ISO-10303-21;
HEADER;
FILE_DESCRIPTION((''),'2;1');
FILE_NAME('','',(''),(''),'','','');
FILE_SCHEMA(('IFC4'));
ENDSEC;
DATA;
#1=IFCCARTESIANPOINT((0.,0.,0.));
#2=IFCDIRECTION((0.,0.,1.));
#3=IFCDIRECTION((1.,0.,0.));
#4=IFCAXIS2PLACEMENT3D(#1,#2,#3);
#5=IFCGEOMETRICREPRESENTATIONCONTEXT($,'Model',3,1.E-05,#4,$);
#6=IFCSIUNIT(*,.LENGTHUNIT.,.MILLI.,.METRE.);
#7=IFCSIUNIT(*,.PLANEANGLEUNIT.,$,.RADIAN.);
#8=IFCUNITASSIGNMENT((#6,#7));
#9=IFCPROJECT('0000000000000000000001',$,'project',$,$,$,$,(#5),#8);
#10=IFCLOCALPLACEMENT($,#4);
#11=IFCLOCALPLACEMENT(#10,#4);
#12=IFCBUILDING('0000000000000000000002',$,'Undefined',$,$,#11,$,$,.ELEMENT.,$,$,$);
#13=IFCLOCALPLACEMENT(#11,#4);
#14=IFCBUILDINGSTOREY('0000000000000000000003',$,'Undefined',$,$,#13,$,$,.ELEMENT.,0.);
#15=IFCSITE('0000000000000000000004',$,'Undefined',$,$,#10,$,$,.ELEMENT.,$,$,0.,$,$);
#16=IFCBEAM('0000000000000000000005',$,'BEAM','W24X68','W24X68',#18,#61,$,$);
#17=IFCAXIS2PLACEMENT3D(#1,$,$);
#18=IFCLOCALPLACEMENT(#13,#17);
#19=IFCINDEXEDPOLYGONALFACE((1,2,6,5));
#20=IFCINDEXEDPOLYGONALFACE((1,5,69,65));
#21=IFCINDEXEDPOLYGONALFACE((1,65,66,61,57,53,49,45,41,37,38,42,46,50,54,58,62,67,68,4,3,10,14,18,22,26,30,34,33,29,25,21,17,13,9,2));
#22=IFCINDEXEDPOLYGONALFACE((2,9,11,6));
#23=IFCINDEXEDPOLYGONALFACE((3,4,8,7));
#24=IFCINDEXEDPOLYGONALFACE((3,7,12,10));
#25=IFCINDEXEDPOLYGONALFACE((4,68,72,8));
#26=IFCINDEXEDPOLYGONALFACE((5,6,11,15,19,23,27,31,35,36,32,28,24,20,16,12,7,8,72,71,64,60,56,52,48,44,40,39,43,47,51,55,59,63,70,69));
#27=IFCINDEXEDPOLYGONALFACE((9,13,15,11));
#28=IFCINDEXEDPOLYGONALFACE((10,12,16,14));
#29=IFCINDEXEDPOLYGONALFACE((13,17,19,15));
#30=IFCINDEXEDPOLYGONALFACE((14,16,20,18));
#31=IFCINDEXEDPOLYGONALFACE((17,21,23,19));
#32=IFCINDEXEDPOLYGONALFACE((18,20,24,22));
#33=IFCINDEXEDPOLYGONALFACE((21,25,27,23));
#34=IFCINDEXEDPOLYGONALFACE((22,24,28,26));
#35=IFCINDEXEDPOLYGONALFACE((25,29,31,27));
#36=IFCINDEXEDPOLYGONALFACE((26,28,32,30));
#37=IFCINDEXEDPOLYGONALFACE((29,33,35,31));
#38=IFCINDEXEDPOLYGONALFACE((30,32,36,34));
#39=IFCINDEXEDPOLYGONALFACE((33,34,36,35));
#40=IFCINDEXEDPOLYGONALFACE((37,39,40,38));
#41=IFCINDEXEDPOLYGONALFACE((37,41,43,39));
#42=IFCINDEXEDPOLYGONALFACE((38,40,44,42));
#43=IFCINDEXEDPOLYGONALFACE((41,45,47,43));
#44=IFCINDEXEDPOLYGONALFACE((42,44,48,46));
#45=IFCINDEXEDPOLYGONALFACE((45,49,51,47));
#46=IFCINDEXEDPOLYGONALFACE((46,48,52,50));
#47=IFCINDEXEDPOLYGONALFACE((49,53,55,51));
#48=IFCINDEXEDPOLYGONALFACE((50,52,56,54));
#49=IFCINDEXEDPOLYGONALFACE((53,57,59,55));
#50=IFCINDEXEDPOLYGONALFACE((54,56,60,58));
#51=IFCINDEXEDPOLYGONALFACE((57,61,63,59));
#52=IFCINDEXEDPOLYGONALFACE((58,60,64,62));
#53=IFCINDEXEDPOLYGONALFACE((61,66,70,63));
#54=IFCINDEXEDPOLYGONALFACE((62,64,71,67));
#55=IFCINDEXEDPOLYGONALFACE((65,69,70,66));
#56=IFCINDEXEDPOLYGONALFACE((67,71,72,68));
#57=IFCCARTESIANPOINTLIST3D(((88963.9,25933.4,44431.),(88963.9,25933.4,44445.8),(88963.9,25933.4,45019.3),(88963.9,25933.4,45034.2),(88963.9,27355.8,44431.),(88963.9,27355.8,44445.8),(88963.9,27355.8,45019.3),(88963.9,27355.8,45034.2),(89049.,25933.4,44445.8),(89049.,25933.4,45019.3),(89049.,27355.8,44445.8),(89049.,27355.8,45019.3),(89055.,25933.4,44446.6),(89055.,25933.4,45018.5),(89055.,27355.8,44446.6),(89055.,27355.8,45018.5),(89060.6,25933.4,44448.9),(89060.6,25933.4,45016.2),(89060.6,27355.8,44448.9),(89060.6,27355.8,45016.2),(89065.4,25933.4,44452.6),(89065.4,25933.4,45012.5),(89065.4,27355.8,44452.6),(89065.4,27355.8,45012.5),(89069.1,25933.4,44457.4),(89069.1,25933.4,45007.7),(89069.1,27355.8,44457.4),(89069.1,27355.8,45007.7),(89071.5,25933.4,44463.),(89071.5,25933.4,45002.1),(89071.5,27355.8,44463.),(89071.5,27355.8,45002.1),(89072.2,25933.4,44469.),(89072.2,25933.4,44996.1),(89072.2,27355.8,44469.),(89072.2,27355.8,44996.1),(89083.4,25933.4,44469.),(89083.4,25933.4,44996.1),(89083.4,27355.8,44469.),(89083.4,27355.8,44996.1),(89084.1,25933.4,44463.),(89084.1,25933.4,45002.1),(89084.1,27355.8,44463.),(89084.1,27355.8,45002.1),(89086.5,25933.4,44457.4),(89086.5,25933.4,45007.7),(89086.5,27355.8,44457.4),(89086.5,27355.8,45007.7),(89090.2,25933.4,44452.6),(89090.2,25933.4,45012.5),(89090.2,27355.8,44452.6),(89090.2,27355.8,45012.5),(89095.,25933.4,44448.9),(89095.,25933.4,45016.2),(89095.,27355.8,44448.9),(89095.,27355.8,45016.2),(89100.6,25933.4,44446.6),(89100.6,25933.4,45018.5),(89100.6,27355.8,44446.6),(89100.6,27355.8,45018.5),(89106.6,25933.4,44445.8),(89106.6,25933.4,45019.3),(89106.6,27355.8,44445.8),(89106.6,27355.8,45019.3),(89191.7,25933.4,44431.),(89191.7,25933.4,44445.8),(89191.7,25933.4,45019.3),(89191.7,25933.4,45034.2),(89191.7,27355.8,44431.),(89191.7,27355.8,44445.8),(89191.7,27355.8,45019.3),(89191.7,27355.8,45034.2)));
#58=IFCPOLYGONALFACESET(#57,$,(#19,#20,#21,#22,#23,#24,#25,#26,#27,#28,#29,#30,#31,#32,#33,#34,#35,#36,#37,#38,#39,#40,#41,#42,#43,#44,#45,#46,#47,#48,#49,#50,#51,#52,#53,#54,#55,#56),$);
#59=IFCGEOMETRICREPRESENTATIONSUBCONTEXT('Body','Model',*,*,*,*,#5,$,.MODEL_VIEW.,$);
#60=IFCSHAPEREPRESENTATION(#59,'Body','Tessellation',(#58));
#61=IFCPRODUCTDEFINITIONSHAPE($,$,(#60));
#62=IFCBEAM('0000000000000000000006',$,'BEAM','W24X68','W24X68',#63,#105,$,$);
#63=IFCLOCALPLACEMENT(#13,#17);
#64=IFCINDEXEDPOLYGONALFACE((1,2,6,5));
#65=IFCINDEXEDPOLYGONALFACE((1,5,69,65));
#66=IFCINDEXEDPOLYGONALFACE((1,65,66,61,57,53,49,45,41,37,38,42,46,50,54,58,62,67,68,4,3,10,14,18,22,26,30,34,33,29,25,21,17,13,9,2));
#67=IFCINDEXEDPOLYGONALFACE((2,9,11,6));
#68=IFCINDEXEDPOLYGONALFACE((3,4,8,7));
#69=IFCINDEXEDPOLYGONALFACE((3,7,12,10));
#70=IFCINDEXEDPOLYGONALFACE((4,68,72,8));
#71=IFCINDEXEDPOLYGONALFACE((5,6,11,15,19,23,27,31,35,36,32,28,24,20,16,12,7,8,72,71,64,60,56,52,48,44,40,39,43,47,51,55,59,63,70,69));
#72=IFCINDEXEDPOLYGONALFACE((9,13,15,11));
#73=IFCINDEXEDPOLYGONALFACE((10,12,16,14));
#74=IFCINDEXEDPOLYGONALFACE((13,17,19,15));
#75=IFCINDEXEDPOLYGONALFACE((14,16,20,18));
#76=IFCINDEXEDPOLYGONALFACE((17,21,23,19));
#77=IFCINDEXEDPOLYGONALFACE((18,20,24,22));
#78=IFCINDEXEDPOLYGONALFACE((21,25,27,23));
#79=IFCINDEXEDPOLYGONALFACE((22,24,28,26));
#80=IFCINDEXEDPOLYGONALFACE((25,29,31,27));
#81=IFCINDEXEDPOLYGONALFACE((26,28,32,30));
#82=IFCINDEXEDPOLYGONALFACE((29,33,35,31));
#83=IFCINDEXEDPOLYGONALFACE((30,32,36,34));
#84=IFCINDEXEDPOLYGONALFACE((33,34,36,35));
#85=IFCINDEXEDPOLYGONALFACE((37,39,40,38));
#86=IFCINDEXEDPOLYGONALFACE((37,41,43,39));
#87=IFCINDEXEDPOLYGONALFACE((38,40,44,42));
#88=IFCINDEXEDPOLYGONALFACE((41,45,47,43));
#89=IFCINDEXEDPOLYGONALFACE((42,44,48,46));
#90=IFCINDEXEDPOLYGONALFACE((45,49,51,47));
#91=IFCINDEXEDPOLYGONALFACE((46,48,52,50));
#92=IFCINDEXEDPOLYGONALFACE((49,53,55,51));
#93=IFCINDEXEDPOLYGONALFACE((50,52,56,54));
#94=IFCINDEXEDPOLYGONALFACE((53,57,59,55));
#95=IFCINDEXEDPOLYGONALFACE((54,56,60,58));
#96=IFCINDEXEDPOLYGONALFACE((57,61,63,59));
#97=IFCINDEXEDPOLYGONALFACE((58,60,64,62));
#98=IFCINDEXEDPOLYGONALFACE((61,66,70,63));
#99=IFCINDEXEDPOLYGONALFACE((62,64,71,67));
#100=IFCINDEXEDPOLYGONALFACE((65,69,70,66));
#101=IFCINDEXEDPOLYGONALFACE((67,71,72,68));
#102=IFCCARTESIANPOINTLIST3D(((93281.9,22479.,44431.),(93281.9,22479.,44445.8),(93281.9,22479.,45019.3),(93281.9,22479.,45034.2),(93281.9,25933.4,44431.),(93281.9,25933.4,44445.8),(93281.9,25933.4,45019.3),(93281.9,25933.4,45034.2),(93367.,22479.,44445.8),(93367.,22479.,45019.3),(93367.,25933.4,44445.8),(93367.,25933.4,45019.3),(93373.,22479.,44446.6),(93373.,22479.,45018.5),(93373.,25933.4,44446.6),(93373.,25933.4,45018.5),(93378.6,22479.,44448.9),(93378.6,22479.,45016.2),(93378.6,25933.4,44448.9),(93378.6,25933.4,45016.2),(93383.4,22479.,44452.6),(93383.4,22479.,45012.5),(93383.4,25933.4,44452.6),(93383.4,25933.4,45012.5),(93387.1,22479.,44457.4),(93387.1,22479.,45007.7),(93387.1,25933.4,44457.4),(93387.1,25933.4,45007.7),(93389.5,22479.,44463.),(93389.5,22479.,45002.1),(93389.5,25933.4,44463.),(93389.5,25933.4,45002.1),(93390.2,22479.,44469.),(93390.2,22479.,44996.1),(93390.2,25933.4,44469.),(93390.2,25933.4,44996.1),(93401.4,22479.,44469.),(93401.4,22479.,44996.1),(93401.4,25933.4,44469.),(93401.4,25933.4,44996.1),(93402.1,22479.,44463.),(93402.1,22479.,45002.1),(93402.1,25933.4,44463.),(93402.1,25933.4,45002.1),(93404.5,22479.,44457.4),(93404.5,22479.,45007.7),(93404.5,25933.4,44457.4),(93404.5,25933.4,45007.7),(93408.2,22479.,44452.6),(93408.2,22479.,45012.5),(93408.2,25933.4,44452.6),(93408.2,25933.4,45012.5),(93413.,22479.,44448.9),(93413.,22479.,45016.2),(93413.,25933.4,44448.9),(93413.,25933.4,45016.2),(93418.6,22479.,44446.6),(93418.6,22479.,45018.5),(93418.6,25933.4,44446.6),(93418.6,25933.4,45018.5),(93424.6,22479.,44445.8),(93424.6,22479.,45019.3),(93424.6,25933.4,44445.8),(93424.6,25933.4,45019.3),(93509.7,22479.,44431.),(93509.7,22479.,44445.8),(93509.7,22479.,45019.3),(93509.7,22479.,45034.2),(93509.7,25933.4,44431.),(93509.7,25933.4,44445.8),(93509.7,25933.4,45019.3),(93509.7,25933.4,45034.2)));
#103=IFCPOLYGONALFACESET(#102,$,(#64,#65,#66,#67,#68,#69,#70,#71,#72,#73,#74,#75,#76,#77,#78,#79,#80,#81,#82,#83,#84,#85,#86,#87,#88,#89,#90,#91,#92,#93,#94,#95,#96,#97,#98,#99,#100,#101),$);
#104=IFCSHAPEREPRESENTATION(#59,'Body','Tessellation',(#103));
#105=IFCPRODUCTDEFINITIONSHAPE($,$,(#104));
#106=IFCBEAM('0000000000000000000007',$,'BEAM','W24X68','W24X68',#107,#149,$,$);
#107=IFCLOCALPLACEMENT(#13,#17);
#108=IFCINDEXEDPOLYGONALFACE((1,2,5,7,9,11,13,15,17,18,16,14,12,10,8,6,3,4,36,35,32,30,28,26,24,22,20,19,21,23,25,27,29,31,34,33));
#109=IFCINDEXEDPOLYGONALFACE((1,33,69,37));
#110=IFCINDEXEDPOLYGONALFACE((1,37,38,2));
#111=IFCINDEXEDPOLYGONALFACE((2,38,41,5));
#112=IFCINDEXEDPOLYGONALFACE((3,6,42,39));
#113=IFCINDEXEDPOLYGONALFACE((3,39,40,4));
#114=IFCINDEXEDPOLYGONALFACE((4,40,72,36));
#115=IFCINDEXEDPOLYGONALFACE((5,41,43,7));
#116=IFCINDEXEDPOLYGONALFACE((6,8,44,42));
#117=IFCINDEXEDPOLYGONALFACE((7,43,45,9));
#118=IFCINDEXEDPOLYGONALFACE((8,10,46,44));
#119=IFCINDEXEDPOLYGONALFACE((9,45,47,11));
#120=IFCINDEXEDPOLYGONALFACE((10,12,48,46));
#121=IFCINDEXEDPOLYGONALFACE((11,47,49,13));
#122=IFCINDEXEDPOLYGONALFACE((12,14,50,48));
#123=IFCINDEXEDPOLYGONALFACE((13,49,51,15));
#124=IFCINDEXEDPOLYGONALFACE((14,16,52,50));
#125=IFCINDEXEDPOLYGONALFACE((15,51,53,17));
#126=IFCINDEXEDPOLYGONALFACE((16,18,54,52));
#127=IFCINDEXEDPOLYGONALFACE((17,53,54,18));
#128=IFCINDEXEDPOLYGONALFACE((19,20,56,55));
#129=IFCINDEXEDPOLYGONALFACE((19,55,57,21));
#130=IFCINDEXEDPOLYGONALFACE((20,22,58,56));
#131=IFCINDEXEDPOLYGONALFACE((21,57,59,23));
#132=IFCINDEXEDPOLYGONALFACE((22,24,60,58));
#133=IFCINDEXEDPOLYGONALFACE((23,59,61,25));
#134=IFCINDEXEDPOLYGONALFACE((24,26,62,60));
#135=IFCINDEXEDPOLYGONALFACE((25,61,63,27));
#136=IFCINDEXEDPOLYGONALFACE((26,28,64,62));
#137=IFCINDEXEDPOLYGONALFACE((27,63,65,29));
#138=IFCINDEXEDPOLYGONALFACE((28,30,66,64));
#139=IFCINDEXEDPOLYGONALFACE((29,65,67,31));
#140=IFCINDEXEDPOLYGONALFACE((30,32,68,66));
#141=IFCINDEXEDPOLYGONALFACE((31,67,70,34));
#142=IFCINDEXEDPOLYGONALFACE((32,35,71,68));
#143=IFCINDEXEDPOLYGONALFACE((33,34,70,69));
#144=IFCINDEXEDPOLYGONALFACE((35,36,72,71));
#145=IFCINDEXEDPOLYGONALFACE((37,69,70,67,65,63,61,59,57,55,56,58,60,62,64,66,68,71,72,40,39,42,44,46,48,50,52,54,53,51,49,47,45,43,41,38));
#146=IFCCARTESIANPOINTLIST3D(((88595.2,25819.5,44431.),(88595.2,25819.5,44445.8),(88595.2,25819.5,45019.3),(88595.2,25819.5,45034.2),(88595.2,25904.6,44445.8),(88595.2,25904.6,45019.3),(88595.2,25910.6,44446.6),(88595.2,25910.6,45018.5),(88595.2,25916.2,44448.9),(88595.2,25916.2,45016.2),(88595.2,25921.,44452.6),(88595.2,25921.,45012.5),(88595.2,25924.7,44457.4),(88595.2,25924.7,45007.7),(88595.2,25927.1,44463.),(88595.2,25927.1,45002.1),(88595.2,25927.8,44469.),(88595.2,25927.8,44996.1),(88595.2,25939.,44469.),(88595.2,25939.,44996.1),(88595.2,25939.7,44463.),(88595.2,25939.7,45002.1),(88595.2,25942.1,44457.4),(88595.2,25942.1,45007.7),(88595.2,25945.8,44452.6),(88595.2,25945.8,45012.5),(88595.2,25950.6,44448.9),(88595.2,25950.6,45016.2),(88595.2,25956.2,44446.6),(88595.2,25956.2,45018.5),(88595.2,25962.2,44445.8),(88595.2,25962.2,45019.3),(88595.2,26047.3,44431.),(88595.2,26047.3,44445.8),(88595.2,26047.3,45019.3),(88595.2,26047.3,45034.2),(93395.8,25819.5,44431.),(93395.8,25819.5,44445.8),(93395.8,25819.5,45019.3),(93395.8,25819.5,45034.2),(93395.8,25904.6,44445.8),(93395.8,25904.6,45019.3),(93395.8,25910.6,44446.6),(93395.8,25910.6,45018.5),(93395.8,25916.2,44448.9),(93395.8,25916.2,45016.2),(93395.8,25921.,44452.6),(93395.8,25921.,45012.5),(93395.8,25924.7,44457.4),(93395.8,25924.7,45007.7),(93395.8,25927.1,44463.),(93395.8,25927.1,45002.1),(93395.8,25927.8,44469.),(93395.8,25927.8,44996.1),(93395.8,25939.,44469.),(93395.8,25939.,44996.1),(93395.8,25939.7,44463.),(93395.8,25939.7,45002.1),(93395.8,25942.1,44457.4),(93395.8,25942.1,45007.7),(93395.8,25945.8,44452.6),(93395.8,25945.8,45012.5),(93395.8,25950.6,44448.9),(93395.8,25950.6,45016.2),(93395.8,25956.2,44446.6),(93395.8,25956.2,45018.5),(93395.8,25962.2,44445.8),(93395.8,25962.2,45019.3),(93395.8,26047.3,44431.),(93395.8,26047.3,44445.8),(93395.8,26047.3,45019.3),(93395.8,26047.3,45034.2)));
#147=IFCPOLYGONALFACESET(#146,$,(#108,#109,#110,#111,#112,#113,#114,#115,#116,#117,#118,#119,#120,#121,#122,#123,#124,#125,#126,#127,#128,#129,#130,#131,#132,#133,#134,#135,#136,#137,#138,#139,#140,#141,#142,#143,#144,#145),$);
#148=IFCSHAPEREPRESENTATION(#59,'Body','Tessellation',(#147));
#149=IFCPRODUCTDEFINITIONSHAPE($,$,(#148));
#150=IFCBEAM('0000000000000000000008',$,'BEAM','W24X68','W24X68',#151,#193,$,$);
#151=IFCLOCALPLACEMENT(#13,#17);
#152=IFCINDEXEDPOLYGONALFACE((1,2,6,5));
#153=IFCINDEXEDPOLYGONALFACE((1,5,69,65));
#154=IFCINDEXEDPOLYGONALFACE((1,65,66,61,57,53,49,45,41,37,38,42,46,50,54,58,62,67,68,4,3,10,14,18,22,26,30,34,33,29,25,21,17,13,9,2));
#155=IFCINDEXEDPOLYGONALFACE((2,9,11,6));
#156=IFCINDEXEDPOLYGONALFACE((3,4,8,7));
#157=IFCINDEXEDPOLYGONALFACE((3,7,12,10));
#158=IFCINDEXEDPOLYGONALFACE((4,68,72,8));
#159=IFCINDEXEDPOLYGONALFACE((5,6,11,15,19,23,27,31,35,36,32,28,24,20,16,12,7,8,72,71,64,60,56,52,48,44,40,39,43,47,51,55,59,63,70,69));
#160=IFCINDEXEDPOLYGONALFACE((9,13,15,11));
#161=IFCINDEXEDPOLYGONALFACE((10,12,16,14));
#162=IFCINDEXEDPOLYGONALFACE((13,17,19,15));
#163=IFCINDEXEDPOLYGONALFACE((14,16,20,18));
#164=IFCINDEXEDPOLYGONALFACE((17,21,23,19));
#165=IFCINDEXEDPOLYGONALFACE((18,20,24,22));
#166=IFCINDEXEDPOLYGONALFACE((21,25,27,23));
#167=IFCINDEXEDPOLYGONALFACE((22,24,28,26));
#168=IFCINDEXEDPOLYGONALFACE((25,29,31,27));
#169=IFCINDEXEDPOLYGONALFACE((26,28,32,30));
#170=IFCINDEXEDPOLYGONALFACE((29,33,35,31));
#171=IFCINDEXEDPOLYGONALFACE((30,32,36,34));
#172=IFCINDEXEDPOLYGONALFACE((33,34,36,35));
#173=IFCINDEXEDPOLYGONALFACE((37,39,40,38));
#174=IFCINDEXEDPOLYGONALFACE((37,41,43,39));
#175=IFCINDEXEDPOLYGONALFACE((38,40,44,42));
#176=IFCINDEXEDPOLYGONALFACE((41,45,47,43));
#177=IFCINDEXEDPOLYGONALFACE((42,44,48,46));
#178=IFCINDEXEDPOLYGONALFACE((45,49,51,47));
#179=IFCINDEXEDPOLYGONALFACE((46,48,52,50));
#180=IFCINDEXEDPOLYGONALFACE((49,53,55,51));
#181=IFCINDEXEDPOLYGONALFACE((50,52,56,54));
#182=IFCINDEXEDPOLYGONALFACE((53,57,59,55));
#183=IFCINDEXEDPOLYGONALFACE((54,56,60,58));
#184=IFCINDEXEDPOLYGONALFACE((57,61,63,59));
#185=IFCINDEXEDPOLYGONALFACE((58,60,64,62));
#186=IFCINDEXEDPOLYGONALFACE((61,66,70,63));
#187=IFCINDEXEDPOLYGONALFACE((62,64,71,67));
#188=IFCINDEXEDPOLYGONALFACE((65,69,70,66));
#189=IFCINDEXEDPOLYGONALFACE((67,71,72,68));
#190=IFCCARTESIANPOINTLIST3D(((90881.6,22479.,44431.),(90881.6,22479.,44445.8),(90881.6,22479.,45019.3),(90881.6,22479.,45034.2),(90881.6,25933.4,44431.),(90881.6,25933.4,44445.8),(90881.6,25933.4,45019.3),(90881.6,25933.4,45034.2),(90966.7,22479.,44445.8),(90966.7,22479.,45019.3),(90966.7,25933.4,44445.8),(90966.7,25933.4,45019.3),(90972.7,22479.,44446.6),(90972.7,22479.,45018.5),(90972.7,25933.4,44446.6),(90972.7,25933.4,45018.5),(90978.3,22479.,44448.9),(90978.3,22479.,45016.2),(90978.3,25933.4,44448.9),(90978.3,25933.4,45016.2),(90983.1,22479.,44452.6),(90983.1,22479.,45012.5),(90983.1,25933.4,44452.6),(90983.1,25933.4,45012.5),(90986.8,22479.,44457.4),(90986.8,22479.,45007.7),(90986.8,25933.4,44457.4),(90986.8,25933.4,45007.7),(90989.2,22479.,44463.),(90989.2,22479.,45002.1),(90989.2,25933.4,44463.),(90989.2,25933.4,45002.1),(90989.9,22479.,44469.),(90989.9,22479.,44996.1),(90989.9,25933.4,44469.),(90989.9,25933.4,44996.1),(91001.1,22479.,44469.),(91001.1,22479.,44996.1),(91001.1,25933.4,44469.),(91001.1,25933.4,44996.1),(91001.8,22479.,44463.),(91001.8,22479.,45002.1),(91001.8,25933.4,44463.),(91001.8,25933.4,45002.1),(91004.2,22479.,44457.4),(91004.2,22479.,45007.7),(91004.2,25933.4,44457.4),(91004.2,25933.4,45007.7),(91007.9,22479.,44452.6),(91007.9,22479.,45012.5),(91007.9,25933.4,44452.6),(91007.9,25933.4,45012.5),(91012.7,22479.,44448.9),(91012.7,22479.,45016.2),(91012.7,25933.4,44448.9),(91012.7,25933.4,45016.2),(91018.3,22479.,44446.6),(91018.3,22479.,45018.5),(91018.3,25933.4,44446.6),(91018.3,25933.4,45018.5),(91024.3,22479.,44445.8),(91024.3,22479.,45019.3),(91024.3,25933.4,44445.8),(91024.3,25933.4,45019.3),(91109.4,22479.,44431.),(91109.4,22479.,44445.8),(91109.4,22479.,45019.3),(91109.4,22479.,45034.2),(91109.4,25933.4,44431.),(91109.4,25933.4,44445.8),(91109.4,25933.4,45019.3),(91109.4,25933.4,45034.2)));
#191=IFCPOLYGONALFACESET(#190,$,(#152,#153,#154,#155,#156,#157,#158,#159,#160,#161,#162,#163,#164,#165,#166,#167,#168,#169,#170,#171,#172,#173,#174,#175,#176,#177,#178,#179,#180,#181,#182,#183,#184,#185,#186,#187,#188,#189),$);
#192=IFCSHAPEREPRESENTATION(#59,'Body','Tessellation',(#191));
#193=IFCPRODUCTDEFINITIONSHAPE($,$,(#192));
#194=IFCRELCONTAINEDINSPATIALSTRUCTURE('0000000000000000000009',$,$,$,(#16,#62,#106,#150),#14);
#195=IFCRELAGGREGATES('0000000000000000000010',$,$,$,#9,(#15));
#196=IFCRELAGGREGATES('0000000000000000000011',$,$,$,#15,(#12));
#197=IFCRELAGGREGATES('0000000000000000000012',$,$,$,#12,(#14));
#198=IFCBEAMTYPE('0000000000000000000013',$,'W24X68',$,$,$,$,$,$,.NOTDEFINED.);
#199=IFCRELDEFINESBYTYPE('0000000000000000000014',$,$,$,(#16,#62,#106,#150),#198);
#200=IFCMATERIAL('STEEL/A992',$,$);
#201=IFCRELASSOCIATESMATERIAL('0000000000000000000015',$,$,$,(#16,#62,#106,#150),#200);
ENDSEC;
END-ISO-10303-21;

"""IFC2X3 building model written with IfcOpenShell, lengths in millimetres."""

from ifc_helpers import new_model, si_unit, frame, origin_with_axes, origin_2d_with_axis, place, context, subcontext, project, spatial, i_section, extrude, material, type_object, element, save


model = new_model("IFC2X3")

# Units and contexts
model_context = context("Model", 3, precision=1e-05, world=origin_with_axes())
body_context = subcontext(model_context, "Body", "Model", "MODEL_VIEW")
ifc_project = project(units=[si_unit("LENGTHUNIT", "METRE", prefix="MILLI"), si_unit("PLANEANGLEUNIT", "RADIAN")], contexts=[model_context])

# Site, building, storey
site_placement = place(None, origin_with_axes())
site = spatial("IfcSite", under=ifc_project, at=site_placement, Name="Undefined", CompositionType="ELEMENT", RefElevation=0.0)
building_placement = place(site_placement, origin_with_axes())
building = spatial("IfcBuilding", under=site, at=building_placement, Name="Undefined", CompositionType="ELEMENT")
storey_placement = place(building_placement, origin_with_axes())
storey = spatial("IfcBuildingStorey", under=building, at=storey_placement, Name="Undefined", CompositionType="ELEMENT", Elevation=0.0)

# Shared definitions
ifc_material = material(Name="STEEL/A992")

# Beams
beam_type = type_object("IfcBeamType", Name="W24X68", PredefinedType="NOTDEFINED")
beam_1_placement = place(storey_placement, frame((89077.8, 25933.4, 44732.6), z_axis=(0.0, 0.0, 1.0), x_axis=(0.0, 1.0, 0.0)))
element("IfcBeam", 1, at=beam_1_placement, inside=storey, type_object=beam_type, material=ifc_material, Name="BEAM", Description="W24X68", ObjectType="W24X68", context=body_context, shape_type="SweptSolid", body=[
    extrude(i_section(OverallWidth=227.8, OverallDepth=603.2, WebThickness=11.1, FlangeThickness=14.9, FilletRadius=23.2, at=origin_2d_with_axis()), frame((1422.4, 0.0, 0.0), z_axis=(-1.0, 0.0, 0.0), x_axis=(0.0, -1.0, 0.0)), (0.0, 0.0, 1.0), 1422.4),
])
beam_2_placement = place(storey_placement, frame((93395.8, 22479.0, 44732.6), z_axis=(0.0, 0.0, 1.0), x_axis=(0.0, 1.0, 0.0)))
element("IfcBeam", 2, at=beam_2_placement, inside=storey, type_object=beam_type, material=ifc_material, Name="BEAM", Description="W24X68", ObjectType="W24X68", context=body_context, shape_type="SweptSolid", body=[
    extrude(i_section(OverallWidth=227.8, OverallDepth=603.2, WebThickness=11.1, FlangeThickness=14.9, FilletRadius=23.2, at=origin_2d_with_axis()), frame((3454.4, 0.0, 0.0), z_axis=(-1.0, 0.0, 0.0), x_axis=(0.0, -1.0, 0.0)), (0.0, 0.0, 1.0), 3454.4),
])
beam_3_placement = place(storey_placement, frame((88595.2, 25933.4, 44732.6), z_axis=(0.0, 0.0, 1.0), x_axis=(1.0, 0.0, 0.0)))
element("IfcBeam", 3, at=beam_3_placement, inside=storey, type_object=beam_type, material=ifc_material, Name="BEAM", Description="W24X68", ObjectType="W24X68", context=body_context, shape_type="SweptSolid", body=[
    extrude(i_section(OverallWidth=227.8, OverallDepth=603.2, WebThickness=11.1, FlangeThickness=14.9, FilletRadius=23.2, at=origin_2d_with_axis()), frame((4800.6, 0.0, 0.0), z_axis=(-1.0, 0.0, 0.0), x_axis=(0.0, -1.0, 0.0)), (0.0, 0.0, 1.0), 4800.6),
])
beam_4_placement = place(storey_placement, frame((90995.5, 22479.0, 44732.6), z_axis=(0.0, 0.0, 1.0), x_axis=(0.0, 1.0, 0.0)))
element("IfcBeam", 4, at=beam_4_placement, inside=storey, type_object=beam_type, material=ifc_material, Name="BEAM", Description="W24X68", ObjectType="W24X68", context=body_context, shape_type="SweptSolid", body=[
    extrude(i_section(OverallWidth=227.8, OverallDepth=603.2, WebThickness=11.1, FlangeThickness=14.9, FilletRadius=23.2, at=origin_2d_with_axis()), frame((3454.4, 0.0, 0.0), z_axis=(-1.0, 0.0, 0.0), x_axis=(0.0, -1.0, 0.0)), (0.0, 0.0, 1.0), 3454.4),
])

save(model, "model.ifc")
